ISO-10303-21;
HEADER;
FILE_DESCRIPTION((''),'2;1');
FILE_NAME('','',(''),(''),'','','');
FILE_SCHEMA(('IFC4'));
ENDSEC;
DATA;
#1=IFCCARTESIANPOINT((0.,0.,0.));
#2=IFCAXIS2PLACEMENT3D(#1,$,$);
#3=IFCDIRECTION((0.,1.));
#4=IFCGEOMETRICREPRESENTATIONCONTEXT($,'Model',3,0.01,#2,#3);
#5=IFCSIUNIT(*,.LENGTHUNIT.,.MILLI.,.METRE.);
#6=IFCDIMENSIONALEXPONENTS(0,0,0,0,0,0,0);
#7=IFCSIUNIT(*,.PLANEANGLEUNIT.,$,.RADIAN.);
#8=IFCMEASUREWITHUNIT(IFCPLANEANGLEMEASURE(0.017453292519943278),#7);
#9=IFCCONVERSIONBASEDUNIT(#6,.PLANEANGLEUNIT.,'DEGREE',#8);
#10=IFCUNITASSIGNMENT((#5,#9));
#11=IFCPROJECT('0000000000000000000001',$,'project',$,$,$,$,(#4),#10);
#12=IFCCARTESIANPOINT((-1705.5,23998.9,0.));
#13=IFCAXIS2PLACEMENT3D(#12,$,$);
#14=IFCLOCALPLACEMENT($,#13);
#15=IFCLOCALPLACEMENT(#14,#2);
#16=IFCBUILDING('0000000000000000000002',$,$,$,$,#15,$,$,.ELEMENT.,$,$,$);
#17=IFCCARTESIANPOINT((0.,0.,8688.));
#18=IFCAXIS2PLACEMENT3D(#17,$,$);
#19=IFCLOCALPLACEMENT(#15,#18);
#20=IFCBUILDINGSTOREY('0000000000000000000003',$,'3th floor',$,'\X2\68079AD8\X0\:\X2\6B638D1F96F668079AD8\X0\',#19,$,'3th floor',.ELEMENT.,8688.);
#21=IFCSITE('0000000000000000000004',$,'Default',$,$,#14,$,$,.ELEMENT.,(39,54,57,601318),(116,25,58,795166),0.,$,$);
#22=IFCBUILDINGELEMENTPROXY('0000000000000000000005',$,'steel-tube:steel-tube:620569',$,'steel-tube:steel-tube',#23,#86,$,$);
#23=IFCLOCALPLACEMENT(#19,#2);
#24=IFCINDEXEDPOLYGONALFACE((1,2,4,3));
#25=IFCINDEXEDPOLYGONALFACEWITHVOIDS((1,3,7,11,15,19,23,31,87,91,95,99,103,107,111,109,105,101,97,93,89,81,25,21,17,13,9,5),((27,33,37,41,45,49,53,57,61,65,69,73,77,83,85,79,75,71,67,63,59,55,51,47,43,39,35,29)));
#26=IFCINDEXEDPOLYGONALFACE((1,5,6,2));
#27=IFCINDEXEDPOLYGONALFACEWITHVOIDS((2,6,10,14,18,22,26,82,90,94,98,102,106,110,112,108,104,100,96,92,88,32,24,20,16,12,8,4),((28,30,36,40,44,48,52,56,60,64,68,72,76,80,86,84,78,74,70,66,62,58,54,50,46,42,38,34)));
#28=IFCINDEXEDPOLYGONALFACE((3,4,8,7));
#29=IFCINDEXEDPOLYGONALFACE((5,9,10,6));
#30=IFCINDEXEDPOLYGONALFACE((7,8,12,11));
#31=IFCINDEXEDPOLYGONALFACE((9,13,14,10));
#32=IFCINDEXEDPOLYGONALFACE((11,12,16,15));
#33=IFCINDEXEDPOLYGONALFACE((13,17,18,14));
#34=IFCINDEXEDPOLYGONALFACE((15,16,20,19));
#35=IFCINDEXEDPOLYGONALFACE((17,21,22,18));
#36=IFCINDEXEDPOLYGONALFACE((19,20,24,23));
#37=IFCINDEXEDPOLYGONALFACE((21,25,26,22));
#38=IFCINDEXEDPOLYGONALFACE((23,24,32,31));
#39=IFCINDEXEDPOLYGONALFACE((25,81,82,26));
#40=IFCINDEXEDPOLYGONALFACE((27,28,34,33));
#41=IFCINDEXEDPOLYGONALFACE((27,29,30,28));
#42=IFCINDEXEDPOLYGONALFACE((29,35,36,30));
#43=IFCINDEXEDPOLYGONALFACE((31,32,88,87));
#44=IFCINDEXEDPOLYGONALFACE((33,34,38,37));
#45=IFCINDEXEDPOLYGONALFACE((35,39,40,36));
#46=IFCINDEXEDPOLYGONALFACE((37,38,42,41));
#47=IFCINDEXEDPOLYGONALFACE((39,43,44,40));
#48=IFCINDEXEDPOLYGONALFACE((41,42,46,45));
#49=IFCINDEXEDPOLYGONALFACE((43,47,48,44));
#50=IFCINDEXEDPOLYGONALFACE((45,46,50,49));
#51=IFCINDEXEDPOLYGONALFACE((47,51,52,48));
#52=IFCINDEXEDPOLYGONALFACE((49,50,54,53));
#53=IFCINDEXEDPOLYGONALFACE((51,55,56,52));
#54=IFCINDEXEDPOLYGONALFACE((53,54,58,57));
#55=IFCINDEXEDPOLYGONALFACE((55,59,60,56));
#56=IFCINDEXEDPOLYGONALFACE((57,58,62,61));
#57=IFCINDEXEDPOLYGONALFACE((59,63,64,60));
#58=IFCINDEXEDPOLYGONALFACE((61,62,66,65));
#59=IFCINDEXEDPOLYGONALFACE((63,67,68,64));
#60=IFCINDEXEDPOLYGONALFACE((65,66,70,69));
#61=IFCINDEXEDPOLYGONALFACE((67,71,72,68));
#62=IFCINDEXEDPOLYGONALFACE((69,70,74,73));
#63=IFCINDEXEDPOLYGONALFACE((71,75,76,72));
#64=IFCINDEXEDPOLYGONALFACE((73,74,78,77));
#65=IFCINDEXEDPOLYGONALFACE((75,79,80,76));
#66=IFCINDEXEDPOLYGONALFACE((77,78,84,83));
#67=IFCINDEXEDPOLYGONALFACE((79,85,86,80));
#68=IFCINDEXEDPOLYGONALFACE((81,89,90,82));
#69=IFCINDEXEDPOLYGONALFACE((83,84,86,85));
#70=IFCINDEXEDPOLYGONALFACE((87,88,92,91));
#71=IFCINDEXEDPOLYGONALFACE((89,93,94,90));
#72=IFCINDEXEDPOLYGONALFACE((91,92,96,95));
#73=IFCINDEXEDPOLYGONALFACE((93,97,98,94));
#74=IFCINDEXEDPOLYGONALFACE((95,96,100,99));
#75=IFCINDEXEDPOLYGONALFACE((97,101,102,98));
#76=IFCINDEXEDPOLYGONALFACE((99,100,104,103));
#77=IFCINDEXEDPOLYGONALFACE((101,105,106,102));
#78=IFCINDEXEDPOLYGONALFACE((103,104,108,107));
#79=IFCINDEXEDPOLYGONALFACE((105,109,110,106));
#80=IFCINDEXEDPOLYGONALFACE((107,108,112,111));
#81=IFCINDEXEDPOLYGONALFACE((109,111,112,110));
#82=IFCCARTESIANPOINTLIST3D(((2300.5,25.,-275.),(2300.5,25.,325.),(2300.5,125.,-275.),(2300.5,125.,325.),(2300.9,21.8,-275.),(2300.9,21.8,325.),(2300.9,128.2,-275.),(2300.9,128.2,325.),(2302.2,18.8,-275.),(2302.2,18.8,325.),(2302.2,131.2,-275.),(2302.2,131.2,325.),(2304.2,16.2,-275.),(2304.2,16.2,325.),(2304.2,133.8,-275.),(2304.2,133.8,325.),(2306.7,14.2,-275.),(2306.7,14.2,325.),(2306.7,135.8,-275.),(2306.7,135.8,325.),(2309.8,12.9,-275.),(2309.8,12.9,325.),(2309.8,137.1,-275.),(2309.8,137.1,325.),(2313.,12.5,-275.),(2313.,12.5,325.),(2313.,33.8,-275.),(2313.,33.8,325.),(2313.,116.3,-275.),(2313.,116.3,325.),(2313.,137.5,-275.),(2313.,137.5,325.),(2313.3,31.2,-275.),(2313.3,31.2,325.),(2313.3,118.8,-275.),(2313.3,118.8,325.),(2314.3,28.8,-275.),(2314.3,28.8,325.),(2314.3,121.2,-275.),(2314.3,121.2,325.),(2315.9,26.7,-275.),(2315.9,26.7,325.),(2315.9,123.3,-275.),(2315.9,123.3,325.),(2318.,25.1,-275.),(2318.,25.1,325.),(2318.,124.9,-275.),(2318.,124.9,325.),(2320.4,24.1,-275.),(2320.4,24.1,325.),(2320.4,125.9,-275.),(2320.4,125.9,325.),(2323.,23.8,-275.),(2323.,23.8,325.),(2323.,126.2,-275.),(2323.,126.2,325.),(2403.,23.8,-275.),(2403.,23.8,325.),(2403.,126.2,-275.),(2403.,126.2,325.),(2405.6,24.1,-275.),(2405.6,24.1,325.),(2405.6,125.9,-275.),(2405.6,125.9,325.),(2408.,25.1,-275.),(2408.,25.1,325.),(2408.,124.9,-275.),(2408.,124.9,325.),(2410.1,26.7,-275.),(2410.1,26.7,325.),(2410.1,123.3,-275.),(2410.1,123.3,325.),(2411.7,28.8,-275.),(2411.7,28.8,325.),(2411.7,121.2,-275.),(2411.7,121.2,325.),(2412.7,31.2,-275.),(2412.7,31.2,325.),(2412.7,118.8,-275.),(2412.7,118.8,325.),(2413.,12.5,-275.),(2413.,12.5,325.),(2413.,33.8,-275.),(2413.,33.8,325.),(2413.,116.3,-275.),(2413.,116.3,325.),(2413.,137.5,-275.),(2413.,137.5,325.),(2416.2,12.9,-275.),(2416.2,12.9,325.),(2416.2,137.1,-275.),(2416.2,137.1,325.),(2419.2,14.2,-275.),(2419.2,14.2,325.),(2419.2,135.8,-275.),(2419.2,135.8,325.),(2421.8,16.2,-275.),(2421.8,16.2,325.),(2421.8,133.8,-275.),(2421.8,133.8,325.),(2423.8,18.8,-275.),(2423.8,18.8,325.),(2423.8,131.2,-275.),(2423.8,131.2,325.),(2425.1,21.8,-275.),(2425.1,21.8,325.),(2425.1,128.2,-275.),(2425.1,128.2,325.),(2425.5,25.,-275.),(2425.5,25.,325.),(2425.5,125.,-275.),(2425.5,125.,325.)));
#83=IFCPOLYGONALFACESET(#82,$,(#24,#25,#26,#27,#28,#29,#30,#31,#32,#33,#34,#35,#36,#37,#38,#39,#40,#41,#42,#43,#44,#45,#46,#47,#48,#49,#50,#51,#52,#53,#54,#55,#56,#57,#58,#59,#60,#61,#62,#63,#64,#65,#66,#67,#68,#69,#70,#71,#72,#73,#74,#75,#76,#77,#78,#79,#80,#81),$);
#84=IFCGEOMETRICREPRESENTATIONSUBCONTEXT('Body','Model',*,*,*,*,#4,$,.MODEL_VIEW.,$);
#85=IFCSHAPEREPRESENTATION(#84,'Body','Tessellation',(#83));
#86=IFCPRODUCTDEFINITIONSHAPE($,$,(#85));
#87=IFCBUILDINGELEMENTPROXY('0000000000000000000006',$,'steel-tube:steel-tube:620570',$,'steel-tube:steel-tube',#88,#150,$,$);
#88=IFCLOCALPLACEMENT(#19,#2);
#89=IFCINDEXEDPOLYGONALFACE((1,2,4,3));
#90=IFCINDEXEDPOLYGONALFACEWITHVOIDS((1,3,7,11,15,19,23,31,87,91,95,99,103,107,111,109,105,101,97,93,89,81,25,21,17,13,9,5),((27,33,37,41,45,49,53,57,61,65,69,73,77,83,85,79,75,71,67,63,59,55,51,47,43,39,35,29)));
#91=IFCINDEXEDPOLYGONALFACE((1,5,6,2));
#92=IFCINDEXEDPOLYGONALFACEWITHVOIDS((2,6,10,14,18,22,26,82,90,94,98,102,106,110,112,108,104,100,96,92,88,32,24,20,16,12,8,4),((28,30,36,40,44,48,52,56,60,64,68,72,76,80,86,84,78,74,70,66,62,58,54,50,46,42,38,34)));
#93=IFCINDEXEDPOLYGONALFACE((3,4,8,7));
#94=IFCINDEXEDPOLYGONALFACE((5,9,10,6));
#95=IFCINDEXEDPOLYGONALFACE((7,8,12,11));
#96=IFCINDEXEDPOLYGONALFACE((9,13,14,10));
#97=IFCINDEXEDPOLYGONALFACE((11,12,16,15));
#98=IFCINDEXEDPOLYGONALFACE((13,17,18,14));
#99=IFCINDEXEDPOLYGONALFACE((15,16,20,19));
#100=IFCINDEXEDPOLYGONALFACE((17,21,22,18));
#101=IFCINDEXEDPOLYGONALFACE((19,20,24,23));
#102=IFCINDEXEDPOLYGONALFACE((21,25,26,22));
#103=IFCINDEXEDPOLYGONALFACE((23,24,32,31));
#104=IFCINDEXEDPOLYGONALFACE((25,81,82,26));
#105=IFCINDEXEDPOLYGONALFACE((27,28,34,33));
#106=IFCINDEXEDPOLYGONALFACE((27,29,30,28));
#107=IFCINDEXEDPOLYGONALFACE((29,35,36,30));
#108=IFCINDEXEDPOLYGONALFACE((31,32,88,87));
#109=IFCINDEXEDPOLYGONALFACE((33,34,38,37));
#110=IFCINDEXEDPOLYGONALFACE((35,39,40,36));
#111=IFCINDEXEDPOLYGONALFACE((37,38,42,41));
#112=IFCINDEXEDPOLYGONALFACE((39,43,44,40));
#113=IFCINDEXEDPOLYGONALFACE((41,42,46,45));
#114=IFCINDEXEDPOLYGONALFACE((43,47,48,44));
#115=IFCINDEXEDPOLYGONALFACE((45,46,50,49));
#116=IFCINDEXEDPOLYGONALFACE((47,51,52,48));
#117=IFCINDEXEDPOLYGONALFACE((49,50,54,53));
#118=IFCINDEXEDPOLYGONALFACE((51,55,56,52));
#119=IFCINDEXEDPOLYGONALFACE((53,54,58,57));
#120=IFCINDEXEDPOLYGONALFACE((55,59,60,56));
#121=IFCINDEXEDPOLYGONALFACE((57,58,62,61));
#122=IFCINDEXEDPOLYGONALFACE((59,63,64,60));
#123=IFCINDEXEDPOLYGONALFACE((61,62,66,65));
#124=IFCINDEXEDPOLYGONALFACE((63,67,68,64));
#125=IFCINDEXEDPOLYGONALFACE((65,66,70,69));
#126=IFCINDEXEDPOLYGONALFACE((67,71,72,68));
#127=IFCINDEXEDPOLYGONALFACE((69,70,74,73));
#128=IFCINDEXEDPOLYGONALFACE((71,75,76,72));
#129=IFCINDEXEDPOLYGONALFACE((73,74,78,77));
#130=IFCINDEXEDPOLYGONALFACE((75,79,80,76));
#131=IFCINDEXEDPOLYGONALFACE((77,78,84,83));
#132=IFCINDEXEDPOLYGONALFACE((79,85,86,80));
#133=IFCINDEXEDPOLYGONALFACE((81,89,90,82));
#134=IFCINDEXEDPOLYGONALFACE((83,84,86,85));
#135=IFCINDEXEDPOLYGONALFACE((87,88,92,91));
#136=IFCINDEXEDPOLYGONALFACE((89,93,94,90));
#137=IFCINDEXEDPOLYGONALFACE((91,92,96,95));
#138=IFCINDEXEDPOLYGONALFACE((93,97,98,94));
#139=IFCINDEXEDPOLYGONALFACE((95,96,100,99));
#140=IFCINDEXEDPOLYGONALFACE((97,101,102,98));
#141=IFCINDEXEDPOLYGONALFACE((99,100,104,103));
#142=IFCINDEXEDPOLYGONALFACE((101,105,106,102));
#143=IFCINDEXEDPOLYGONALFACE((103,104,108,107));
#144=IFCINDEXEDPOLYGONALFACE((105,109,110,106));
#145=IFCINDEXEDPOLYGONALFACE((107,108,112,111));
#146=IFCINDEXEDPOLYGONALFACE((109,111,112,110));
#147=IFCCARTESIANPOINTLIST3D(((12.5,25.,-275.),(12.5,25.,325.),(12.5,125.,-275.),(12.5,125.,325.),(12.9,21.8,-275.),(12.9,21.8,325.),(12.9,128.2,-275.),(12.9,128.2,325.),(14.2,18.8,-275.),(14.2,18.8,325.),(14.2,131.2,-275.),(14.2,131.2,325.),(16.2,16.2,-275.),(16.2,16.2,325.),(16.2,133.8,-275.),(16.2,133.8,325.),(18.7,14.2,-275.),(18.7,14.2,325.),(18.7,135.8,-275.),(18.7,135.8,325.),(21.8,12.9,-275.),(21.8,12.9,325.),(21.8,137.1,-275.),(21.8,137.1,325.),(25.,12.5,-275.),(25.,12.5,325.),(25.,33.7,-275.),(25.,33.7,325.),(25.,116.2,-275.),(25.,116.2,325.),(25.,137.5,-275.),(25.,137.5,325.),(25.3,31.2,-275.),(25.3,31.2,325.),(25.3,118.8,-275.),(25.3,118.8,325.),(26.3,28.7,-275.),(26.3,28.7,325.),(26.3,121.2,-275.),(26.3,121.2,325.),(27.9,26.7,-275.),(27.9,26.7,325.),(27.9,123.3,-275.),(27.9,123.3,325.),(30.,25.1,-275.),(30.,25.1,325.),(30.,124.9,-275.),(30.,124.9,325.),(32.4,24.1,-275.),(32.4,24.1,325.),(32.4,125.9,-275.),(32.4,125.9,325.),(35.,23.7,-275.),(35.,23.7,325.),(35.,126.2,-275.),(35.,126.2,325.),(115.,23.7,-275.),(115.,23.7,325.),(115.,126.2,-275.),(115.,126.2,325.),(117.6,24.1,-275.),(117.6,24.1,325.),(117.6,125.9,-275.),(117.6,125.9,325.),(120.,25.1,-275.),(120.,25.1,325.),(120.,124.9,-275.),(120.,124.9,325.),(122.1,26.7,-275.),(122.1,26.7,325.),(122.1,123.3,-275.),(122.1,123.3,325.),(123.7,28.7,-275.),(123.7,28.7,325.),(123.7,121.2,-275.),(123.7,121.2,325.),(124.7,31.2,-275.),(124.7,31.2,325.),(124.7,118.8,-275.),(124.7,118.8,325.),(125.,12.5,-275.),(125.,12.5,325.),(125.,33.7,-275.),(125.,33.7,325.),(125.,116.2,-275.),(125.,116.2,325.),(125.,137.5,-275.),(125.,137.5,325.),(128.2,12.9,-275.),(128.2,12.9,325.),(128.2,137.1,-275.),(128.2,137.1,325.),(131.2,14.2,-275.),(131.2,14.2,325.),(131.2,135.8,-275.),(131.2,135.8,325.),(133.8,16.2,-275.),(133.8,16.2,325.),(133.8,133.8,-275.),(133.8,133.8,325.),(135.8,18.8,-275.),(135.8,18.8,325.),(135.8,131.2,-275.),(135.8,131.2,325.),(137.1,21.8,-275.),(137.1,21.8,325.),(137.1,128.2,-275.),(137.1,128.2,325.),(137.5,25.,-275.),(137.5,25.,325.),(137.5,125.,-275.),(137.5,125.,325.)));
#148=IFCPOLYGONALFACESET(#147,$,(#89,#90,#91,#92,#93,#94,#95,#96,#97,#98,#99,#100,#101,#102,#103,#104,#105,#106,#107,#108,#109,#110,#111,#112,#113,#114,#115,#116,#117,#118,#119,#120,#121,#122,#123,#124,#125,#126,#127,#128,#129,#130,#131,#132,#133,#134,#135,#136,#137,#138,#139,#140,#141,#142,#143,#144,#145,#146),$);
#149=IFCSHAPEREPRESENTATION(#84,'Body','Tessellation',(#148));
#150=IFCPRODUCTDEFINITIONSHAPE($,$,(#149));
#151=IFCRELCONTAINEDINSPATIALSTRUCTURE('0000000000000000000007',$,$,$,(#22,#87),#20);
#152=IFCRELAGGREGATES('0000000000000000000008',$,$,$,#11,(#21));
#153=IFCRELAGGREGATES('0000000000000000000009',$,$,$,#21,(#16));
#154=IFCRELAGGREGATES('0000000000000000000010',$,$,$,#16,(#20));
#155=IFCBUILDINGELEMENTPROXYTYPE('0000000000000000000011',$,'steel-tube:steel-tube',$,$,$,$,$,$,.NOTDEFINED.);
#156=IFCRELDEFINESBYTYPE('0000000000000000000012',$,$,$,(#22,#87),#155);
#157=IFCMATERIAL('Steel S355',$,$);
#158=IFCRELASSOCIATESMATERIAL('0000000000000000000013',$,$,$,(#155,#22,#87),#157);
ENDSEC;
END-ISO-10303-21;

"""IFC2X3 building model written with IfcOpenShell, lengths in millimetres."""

from ifc_helpers import new_model, entity, si_unit, converted_unit, direction, frame, frame_2d, origin, place, context, subcontext, project, spatial, polyline, circle_curve, parameter, trimmed, segment, composite_curve, outline, extrude, source, transform, mapped, material, type_object, type_shapes, element, save


model = new_model("IFC2X3")

# Units and contexts
model_context = context("Model", 3, precision=0.01, world=origin(), true_north=direction((0.0, 1.0)))
body_context = subcontext(model_context, "Body", "Model", "MODEL_VIEW")
ifc_project = project(units=[si_unit("LENGTHUNIT", "METRE", prefix="MILLI"), converted_unit("PLANEANGLEUNIT", "DEGREE", entity("IfcPlaneAngleMeasure", 0.017453292519943278), si_unit("PLANEANGLEUNIT", "RADIAN"), dimensions=[0, 0, 0, 0, 0, 0, 0])], contexts=[model_context])

# Site, building, storey
site_placement = place(None, frame((-1705.5, 23998.9, 0.0)))
site = spatial("IfcSite", under=ifc_project, at=site_placement, Name="Default", CompositionType="ELEMENT", RefLatitude=(39, 54, 57, 601318), RefLongitude=(116, 25, 58, 795166), RefElevation=0.0)
building_placement = place(site_placement, origin())
building = spatial("IfcBuilding", under=site, at=building_placement, CompositionType="ELEMENT")
storey_placement = place(building_placement, frame((0.0, 0.0, 8688.0)))
storey = spatial("IfcBuildingStorey", under=building, at=storey_placement, Name="3th floor", ObjectType="标高:正负零标高", LongName="3th floor", CompositionType="ELEMENT", Elevation=8688.0)

# Shared definitions
ifc_material_1 = material(Name="Steel S355")

# Building element proxies
building_element_proxy_type_1 = type_object("IfcBuildingElementProxyType", Name="steel-tube:steel-tube", PredefinedType="NOTDEFINED", material=ifc_material_1)
shared_shape_1 = source(origin(), body_context, "Body", "SweptSolid", [
    extrude(outline(composite_curve([segment(trimmed(circle_curve(frame_2d((50.0, -50.0), x_axis=(1.0, 0.0)), 12.5), [parameter(270.0)], [parameter(0.0)], True, "PARAMETER"), True, "CONTINUOUS"), segment(polyline([(62.5, -50.0), (62.5, 50.0)]), True, "CONTINUOUS"), segment(trimmed(circle_curve(frame_2d((50.0, 50.0), x_axis=(1.0, 0.0)), 12.5), [parameter(0.0)], [parameter(90.0)], True, "PARAMETER"), True, "CONTINUOUS"), segment(polyline([(50.0, 62.5), (-50.0, 62.5)]), True, "CONTINUOUS"), segment(trimmed(circle_curve(frame_2d((-50.0, 50.0), x_axis=(1.0, 0.0)), 12.5), [parameter(90.0)], [parameter(180.0)], True, "PARAMETER"), True, "CONTINUOUS"), segment(polyline([(-62.5, 50.0), (-62.5, -50.0)]), True, "CONTINUOUS"), segment(trimmed(circle_curve(frame_2d((-50.0, -50.0), x_axis=(1.0, 0.0)), 12.5), [parameter(180.0)], [parameter(270.0)], True, "PARAMETER"), True, "CONTINUOUS"), segment(polyline([(-50.0, -62.5), (50.0, -62.5)]), True, "CONTINUOUS")], self_intersect=False), holes=[composite_curve([segment(trimmed(circle_curve(frame_2d((-41.2, 40.0), x_axis=(1.0, 0.0)), 10.0), [parameter(90.0)], [parameter(180.0)], True, "PARAMETER"), False, "CONTINUOUS"), segment(polyline([(-41.3, 50.0), (41.2, 50.0)]), True, "CONTINUOUS"), segment(trimmed(circle_curve(frame_2d((41.2, 40.0), x_axis=(1.0, 0.0)), 10.0), [parameter(0.0)], [parameter(90.0)], True, "PARAMETER"), False, "CONTINUOUS"), segment(polyline([(51.2, 40.0), (51.2, -40.0)]), True, "CONTINUOUS"), segment(trimmed(circle_curve(frame_2d((41.2, -40.0), x_axis=(1.0, 0.0)), 10.0), [parameter(270.0)], [parameter(360.0)], True, "PARAMETER"), False, "CONTINUOUS"), segment(polyline([(41.2, -50.0), (-41.3, -50.0)]), True, "CONTINUOUS"), segment(trimmed(circle_curve(frame_2d((-41.3, -40.0), x_axis=(1.0, 0.0)), 10.0), [parameter(180.0)], [parameter(270.0)], True, "PARAMETER"), False, "CONTINUOUS"), segment(polyline([(-51.3, -40.0), (-51.3, 40.0)]), True, "CONTINUOUS")], self_intersect=False)]), frame((62.5, 62.5, -175.0)), (0.0, 0.0, 1.0), 600.0),
])
type_shapes(building_element_proxy_type_1, [shared_shape_1])
for number, where, z_axis, x_axis, name in (
    (1, (2300.5, 137.5, -100.0), (0.0, 0.0, 1.0), (0.0, -1.0, 0.0), "steel-tube:steel-tube:620569"),
    (2, (12.5, 137.5, -100.0), (0.0, 0.0, 1.0), (0.0, -1.0, 0.0), "steel-tube:steel-tube:620570"),
):
    element("IfcBuildingElementProxy", number, at=place(storey_placement, frame(where, z_axis=z_axis, x_axis=x_axis)), inside=storey, type_object=building_element_proxy_type_1, material=ifc_material_1, Name=name, ObjectType="steel-tube:steel-tube", context=body_context, shape_type="MappedRepresentation", body=[
        mapped(shared_shape_1, transform((0.0, 0.0, 0.0), scale=1.0)),
    ])

save(model, "model.ifc")
